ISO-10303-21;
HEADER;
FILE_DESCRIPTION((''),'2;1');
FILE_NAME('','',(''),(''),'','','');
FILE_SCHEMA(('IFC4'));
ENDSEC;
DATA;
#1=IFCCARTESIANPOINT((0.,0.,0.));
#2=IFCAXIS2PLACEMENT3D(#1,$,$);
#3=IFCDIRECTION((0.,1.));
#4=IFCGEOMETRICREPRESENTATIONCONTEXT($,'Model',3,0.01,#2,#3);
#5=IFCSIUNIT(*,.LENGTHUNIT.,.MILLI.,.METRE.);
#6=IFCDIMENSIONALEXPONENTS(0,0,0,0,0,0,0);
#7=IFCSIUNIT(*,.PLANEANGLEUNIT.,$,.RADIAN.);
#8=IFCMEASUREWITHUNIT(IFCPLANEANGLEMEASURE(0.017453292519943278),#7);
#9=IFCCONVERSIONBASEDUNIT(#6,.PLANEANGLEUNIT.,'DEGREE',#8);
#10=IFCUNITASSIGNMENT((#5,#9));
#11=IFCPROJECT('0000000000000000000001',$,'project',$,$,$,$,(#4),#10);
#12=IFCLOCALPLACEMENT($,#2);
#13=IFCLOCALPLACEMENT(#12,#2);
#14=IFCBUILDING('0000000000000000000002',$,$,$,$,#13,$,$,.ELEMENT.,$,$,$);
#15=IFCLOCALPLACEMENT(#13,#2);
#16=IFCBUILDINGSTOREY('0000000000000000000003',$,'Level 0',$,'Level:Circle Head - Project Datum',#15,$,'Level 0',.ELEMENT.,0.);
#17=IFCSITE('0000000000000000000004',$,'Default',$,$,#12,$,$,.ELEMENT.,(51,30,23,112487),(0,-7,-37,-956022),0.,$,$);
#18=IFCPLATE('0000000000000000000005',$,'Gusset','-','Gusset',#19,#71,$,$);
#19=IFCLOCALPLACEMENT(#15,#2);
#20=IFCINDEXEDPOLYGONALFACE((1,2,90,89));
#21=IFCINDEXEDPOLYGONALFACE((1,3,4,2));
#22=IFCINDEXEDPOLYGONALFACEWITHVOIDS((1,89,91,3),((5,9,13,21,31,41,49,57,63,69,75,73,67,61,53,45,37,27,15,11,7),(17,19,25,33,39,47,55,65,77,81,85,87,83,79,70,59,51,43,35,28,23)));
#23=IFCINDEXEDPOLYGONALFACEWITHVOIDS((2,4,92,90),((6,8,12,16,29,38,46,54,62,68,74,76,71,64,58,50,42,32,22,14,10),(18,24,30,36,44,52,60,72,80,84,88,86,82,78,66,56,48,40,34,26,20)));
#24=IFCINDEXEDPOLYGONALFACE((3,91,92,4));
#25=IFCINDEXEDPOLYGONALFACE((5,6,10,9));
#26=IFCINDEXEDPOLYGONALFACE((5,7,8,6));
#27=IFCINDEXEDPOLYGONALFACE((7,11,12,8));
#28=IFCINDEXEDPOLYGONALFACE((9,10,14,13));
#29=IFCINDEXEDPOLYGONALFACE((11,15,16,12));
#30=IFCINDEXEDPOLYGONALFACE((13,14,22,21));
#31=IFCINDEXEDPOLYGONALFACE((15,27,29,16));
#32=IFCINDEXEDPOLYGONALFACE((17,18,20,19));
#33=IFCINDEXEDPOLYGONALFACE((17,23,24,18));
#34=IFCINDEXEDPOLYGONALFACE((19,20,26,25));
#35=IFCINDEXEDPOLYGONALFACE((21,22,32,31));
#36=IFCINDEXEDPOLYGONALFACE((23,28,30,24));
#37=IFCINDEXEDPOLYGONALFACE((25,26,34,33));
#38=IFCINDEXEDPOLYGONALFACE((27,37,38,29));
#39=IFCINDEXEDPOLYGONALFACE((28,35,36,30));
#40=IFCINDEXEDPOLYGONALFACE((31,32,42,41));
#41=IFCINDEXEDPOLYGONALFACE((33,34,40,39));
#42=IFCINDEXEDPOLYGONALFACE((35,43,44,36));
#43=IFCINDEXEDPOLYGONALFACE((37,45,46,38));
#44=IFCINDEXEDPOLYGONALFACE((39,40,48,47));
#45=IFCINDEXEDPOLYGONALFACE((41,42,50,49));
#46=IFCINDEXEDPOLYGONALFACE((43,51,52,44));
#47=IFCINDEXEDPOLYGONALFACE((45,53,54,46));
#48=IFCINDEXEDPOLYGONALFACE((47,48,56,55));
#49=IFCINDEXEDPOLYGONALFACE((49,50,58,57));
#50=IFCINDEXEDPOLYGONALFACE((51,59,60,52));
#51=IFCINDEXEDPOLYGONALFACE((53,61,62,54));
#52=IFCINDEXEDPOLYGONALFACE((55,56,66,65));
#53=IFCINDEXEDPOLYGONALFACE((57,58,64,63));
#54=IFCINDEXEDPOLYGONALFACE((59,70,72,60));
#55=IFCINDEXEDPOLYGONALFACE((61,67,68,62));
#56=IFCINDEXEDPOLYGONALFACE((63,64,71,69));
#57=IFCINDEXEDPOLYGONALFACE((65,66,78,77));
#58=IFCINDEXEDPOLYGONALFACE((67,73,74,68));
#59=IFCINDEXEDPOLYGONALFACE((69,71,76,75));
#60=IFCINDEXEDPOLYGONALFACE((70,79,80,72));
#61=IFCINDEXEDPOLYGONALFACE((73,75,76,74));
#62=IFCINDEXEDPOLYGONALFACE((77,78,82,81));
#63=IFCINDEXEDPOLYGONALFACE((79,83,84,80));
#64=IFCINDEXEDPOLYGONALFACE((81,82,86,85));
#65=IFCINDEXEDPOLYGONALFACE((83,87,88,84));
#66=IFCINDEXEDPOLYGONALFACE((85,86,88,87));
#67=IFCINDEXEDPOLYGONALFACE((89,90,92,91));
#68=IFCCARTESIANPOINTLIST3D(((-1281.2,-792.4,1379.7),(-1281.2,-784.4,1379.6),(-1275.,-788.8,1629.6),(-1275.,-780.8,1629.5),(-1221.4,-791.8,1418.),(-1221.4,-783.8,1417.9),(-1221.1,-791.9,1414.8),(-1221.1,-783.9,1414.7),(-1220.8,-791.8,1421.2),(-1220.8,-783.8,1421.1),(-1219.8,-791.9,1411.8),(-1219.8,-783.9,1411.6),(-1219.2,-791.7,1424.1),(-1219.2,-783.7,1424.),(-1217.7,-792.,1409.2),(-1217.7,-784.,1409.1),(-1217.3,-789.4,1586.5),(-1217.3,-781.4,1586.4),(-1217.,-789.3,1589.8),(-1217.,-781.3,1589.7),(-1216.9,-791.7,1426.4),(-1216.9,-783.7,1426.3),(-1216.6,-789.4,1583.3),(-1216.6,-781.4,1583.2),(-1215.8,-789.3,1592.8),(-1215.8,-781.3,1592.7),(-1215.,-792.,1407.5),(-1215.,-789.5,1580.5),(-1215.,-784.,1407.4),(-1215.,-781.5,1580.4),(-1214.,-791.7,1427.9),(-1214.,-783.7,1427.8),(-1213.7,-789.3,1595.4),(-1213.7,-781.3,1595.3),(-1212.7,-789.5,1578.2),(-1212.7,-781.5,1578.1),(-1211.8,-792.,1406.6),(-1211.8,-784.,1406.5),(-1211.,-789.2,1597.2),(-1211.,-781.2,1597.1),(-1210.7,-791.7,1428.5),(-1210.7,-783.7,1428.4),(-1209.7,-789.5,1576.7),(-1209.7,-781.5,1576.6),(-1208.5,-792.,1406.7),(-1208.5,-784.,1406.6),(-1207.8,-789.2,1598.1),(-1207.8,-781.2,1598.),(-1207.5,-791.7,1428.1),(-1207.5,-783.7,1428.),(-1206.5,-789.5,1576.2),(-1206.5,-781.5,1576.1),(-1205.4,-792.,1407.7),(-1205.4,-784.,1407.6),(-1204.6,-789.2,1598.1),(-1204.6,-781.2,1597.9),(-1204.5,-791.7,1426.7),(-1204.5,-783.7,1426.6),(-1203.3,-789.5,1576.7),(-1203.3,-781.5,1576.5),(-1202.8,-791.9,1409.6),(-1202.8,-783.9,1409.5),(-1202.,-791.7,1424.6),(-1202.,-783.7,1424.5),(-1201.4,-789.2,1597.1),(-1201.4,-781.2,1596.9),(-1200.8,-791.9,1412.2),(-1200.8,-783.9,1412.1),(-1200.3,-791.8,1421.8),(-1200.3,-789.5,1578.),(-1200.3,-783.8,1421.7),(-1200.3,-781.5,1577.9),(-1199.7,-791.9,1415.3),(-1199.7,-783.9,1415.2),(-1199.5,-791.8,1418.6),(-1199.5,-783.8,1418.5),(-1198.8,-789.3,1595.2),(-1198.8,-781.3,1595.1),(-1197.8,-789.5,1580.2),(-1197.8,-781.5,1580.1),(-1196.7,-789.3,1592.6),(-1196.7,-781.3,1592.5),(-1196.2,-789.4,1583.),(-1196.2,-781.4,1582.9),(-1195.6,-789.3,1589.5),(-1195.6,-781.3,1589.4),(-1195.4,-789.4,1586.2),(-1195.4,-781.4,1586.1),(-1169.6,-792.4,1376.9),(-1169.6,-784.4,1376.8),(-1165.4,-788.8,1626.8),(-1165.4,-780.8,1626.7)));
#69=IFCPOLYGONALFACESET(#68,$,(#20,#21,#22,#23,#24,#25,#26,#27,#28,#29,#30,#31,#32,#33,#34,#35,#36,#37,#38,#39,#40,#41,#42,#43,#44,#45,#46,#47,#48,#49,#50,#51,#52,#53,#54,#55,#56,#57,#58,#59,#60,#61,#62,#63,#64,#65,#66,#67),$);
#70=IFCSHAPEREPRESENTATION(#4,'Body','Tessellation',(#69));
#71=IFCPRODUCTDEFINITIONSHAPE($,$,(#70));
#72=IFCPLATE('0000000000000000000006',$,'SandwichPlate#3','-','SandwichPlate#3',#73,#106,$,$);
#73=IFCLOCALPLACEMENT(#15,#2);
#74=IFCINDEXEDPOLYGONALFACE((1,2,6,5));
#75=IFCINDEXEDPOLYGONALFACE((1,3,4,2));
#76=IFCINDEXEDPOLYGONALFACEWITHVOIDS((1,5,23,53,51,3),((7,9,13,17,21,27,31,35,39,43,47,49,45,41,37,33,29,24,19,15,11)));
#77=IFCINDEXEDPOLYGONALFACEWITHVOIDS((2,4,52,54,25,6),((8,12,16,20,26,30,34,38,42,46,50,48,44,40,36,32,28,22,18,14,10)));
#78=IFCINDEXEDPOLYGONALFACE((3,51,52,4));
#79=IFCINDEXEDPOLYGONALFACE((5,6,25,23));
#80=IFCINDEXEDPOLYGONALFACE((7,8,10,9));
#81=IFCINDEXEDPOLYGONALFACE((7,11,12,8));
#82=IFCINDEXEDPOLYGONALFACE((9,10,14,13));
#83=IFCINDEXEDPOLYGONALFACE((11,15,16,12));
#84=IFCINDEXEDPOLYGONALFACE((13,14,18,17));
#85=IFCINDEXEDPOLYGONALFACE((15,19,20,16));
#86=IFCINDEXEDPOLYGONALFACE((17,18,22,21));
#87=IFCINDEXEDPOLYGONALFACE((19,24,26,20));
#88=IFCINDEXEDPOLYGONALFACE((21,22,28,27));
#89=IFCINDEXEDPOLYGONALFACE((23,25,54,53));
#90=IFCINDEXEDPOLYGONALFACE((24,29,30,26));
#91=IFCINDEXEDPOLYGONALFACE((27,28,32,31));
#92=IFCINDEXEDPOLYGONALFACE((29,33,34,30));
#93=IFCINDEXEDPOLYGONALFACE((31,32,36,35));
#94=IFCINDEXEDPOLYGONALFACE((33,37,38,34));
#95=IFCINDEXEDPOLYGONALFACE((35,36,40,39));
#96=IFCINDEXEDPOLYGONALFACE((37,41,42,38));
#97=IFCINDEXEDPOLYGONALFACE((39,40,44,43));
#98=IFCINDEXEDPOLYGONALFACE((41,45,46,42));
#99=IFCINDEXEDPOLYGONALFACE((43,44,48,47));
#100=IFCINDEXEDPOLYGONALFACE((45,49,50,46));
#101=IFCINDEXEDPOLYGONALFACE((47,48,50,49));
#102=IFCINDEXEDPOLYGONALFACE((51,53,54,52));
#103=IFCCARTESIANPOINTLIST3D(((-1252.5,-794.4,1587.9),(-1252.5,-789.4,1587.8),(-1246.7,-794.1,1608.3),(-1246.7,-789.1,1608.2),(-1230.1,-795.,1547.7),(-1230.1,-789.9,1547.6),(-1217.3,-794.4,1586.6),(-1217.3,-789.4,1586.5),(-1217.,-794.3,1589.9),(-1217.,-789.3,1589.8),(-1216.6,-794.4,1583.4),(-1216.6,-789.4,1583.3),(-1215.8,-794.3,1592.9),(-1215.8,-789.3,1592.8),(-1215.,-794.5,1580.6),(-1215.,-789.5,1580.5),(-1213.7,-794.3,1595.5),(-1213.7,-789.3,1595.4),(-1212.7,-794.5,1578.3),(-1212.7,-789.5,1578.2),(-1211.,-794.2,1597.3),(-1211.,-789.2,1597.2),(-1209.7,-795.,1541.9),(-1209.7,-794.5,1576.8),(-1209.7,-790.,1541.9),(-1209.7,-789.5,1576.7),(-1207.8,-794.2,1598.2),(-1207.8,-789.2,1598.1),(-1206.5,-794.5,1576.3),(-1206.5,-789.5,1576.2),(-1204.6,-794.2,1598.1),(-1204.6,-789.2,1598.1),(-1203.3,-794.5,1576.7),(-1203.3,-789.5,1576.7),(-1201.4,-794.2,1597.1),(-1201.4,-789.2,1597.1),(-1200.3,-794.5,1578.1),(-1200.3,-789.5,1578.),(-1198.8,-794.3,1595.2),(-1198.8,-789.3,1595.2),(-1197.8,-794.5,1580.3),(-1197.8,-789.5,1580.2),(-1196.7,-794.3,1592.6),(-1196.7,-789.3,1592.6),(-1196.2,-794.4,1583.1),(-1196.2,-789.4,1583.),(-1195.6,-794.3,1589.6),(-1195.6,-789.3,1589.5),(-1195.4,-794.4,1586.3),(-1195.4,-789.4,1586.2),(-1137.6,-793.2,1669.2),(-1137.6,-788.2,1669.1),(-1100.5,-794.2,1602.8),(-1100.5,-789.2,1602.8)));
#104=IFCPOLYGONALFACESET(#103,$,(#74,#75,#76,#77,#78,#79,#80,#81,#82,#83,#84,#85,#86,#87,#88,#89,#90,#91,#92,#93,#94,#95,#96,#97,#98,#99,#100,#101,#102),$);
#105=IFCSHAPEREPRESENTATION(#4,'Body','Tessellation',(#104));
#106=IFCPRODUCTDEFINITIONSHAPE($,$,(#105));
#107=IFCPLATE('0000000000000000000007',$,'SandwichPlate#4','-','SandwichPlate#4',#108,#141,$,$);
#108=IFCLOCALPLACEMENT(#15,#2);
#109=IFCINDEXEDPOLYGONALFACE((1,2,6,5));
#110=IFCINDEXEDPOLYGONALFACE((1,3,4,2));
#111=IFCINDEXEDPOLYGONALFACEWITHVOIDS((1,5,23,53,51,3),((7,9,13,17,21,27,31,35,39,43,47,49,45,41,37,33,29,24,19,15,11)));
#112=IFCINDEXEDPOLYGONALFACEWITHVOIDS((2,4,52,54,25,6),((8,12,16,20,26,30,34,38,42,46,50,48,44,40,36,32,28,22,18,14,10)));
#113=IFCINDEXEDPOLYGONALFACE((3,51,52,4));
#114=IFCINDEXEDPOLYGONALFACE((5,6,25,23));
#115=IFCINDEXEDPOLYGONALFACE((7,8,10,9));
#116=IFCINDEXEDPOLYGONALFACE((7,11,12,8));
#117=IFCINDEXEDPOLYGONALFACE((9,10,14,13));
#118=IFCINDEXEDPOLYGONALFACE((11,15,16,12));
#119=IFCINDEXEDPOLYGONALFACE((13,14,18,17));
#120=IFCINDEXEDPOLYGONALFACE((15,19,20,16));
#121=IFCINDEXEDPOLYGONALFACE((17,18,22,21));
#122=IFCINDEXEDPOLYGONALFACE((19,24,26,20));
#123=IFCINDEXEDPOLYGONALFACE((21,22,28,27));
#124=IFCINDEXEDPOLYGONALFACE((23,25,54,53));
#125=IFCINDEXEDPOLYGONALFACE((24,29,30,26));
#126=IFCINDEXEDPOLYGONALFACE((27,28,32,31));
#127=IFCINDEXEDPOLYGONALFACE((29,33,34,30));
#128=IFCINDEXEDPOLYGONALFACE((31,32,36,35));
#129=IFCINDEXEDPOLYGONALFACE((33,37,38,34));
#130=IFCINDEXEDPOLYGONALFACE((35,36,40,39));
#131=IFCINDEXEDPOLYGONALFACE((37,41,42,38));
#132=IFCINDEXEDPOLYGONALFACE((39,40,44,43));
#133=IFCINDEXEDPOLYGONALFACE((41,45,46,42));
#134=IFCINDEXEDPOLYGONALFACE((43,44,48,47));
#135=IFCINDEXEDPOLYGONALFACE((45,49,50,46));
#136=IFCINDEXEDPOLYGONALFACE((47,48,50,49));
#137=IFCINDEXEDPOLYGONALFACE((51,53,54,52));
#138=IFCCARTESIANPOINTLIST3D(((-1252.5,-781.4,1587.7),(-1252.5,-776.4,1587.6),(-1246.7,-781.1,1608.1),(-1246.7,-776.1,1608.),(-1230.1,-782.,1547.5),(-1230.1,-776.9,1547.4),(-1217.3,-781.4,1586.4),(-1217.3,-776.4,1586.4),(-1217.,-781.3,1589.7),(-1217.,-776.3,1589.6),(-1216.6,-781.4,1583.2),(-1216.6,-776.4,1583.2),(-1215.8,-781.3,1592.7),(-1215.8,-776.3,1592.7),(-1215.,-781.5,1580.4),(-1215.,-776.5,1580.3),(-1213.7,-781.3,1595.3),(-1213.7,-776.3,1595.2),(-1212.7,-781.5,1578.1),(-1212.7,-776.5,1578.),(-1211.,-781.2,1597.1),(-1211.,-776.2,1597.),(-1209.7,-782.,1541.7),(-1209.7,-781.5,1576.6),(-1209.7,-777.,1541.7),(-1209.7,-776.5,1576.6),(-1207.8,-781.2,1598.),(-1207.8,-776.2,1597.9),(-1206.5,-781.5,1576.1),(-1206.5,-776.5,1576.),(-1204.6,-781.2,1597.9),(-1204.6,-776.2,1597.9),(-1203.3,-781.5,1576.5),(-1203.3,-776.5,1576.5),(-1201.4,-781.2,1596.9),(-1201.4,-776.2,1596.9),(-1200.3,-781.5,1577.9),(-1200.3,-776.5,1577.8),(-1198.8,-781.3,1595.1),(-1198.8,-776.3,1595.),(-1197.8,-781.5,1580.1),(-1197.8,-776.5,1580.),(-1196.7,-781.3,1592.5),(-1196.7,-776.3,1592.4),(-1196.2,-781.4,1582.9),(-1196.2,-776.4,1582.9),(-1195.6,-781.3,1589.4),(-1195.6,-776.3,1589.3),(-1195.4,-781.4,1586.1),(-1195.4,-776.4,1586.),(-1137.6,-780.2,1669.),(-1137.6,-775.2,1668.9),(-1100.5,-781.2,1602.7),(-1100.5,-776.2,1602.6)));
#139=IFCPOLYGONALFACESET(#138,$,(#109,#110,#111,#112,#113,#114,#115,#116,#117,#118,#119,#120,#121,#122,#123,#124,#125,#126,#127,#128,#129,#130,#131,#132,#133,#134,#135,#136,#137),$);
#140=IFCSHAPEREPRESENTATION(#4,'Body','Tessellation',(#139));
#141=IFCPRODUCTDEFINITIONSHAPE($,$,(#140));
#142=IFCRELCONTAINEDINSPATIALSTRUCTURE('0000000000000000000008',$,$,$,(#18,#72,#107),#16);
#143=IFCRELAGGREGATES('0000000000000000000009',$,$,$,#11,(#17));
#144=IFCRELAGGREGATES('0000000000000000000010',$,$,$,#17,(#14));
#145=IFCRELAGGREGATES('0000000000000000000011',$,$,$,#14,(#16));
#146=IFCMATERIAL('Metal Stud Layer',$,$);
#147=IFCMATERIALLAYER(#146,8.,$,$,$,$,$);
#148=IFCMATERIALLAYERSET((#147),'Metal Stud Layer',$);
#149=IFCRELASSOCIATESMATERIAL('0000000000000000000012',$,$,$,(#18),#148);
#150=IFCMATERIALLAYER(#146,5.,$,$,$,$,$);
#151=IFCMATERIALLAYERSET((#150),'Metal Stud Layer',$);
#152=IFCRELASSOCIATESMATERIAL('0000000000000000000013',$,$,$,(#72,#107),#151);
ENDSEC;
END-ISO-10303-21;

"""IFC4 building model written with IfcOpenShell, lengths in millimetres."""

from ifc_helpers import new_model, entity, si_unit, converted_unit, direction, frame, origin, origin_with_axes, origin_2d_with_axis, place, context, project, spatial, polyline, circle, outline, extrude, material, layer, layer_set, element, save


model = new_model("IFC4")

# Units and contexts
model_context = context("Model", 3, precision=0.01, world=origin(), true_north=direction((0.0, 1.0)))
ifc_project = project(units=[si_unit("LENGTHUNIT", "METRE", prefix="MILLI"), converted_unit("PLANEANGLEUNIT", "DEGREE", entity("IfcPlaneAngleMeasure", 0.017453292519943278), si_unit("PLANEANGLEUNIT", "RADIAN"), dimensions=[0, 0, 0, 0, 0, 0, 0])], contexts=[model_context])

# Site, building, storey
site_placement = place(None, origin())
site = spatial("IfcSite", under=ifc_project, at=site_placement, Name="Default", CompositionType="ELEMENT", RefLatitude=(51, 30, 23, 112487), RefLongitude=(0, -7, -37, -956022), RefElevation=0.0)
building_placement = place(site_placement, origin())
building = spatial("IfcBuilding", under=site, at=building_placement, CompositionType="ELEMENT")
storey_placement = place(building_placement, origin())
storey = spatial("IfcBuildingStorey", under=building, at=storey_placement, Name="Level 0", ObjectType="Level:Circle Head - Project Datum", LongName="Level 0", CompositionType="ELEMENT", Elevation=0.0)

# Plates, openings
ifc_material_1 = material(Name="Metal Stud Layer")
ifc_layer_1 = layer(ifc_material_1, 8.0)
ifc_layer_set_1 = layer_set([ifc_layer_1], Name="Metal Stud Layer")
plate_1_placement = place(storey_placement, frame((-1272.8, -780.8, 1628.9), z_axis=(0.0, -0.999896, 0.014432), x_axis=(-0.02499, -0.014428, -0.999584)))
plate_1 = element("IfcPlate", 1, at=plate_1_placement, inside=storey, material=ifc_layer_set_1, Name="Gusset", Description="-", ObjectType="Gusset", context=model_context, shape_type="SweptSolid", body=[
    extrude(outline(polyline([(-0.5, -2.2), (249.5, -2.2), (249.5, 109.5), (-0.5, 107.4), (-0.5, -2.2)])), origin_with_axes(), (0.0, 0.0, 1.0), 8.0),
])
opening_1_placement = place(plate_1_placement, frame((40.2, 67.5, 8.5), z_axis=(0.0, 0.0, -1.0), x_axis=(-0.509073, 0.860723, 0.0)))
element("IfcOpeningElement", 2, at=opening_1_placement, cuts=plate_1, ObjectType="Opening", context=model_context, shape_type="SweptSolid", body=[
    extrude(circle(Radius=11.0, at=origin_2d_with_axis()), origin(), (0.0, 0.0, 1.0), 9.0),
])
opening_2_placement = place(plate_1_placement, frame((209.9, 67.6, 8.5), z_axis=(0.0, 0.0, -1.0), x_axis=(0.455108, 0.890436, 0.0)))
element("IfcOpeningElement", 3, at=opening_2_placement, cuts=plate_1, ObjectType="Opening", context=model_context, shape_type="SweptSolid", body=[
    extrude(circle(Radius=11.0, at=origin_2d_with_axis()), origin(), (0.0, 0.0, 1.0), 9.0),
])
ifc_layer_2 = layer(ifc_material_1, 5.0)
ifc_layer_set_2 = layer_set([ifc_layer_2], Name="Metal Stud Layer")
plate_2_placement = place(storey_placement, frame((-1222.8, -795.1, 1534.6), z_axis=(0.0, 0.999896, -0.014432), x_axis=(-0.487405, 0.012602, 0.873085)))
plate_2 = element("IfcPlate", 4, at=plate_2_placement, inside=storey, material=ifc_layer_set_2, Name="SandwichPlate#3", Description="-", ObjectType="SandwichPlate#3", context=model_context, shape_type="SweptSolid", body=[
    extrude(outline(polyline([(0.0, 0.0), (76.0, 0.0), (76.0, 140.0), (0.0, 140.0), (0.0, 0.0)])), origin_with_axes(), (0.0, 0.0, 1.0), 5.0),
])
opening_3_placement = place(plate_2_placement, frame((0.0, 0.0, 0.0), z_axis=(0.0, 0.0, 1.0), x_axis=(1.0, 0.0, 0.0)))
element("IfcOpeningElement", 5, at=opening_3_placement, cuts=plate_2, ObjectType="Opening", context=model_context, shape_type="SweptSolid", body=[
    extrude(outline(polyline([(0.0, 0.0), (15.0, 0.0), (0.0, 15.0), (0.0, 0.0)])), origin(), (0.0, 0.0, 1.0), 5.0),
])
opening_4_placement = place(plate_2_placement, frame((0.0, 0.0, 0.0), z_axis=(0.0, 0.0, 1.0), x_axis=(1.0, 0.0, 0.0)))
element("IfcOpeningElement", 6, at=opening_4_placement, cuts=plate_2, ObjectType="Opening", context=model_context, shape_type="SweptSolid", body=[
    extrude(outline(polyline([(76.0, 0.0), (76.0, 15.0), (61.0, 0.0), (76.0, 0.0)])), origin(), (0.0, 0.0, 1.0), 5.0),
])
opening_5_placement = place(plate_2_placement, frame((38.0, 40.0, -0.5), z_axis=(0.0, 0.0, 1.0), x_axis=(0.0, 1.0, 0.0)))
element("IfcOpeningElement", 7, at=opening_5_placement, cuts=plate_2, ObjectType="Opening", context=model_context, shape_type="SweptSolid", body=[
    extrude(circle(Radius=11.0, at=origin_2d_with_axis()), origin(), (0.0, 0.0, 1.0), 6.0),
])
plate_3_placement = place(storey_placement, frame((-1222.8, -782.1, 1534.4), z_axis=(0.0, 0.999896, -0.014432), x_axis=(-0.487405, 0.012602, 0.873085)))
plate_3 = element("IfcPlate", 8, at=plate_3_placement, inside=storey, material=ifc_layer_set_2, Name="SandwichPlate#4", Description="-", ObjectType="SandwichPlate#4", context=model_context, shape_type="SweptSolid", body=[
    extrude(outline(polyline([(0.0, 0.0), (76.0, 0.0), (76.0, 140.0), (0.0, 140.0), (0.0, 0.0)])), origin_with_axes(), (0.0, 0.0, 1.0), 5.0),
])
opening_6_placement = place(plate_3_placement, frame((0.0, 0.0, 0.0), z_axis=(0.0, 0.0, 1.0), x_axis=(1.0, 0.0, 0.0)))
element("IfcOpeningElement", 9, at=opening_6_placement, cuts=plate_3, ObjectType="Opening", context=model_context, shape_type="SweptSolid", body=[
    extrude(outline(polyline([(0.0, 0.0), (15.0, 0.0), (0.0, 15.0), (0.0, 0.0)])), origin(), (0.0, 0.0, 1.0), 5.0),
])
opening_7_placement = place(plate_3_placement, frame((0.0, 0.0, 0.0), z_axis=(0.0, 0.0, 1.0), x_axis=(1.0, 0.0, 0.0)))
element("IfcOpeningElement", 10, at=opening_7_placement, cuts=plate_3, ObjectType="Opening", context=model_context, shape_type="SweptSolid", body=[
    extrude(outline(polyline([(76.0, 0.0), (76.0, 15.0), (61.0, 0.0), (76.0, 0.0)])), origin(), (0.0, 0.0, 1.0), 5.0),
])
opening_8_placement = place(plate_3_placement, frame((38.0, 40.0, -0.5), z_axis=(0.0, 0.0, 1.0), x_axis=(0.0, 1.0, 0.0)))
element("IfcOpeningElement", 11, at=opening_8_placement, cuts=plate_3, ObjectType="Opening", context=model_context, shape_type="SweptSolid", body=[
    extrude(circle(Radius=11.0, at=origin_2d_with_axis()), origin(), (0.0, 0.0, 1.0), 6.0),
])

save(model, "model.ifc")
